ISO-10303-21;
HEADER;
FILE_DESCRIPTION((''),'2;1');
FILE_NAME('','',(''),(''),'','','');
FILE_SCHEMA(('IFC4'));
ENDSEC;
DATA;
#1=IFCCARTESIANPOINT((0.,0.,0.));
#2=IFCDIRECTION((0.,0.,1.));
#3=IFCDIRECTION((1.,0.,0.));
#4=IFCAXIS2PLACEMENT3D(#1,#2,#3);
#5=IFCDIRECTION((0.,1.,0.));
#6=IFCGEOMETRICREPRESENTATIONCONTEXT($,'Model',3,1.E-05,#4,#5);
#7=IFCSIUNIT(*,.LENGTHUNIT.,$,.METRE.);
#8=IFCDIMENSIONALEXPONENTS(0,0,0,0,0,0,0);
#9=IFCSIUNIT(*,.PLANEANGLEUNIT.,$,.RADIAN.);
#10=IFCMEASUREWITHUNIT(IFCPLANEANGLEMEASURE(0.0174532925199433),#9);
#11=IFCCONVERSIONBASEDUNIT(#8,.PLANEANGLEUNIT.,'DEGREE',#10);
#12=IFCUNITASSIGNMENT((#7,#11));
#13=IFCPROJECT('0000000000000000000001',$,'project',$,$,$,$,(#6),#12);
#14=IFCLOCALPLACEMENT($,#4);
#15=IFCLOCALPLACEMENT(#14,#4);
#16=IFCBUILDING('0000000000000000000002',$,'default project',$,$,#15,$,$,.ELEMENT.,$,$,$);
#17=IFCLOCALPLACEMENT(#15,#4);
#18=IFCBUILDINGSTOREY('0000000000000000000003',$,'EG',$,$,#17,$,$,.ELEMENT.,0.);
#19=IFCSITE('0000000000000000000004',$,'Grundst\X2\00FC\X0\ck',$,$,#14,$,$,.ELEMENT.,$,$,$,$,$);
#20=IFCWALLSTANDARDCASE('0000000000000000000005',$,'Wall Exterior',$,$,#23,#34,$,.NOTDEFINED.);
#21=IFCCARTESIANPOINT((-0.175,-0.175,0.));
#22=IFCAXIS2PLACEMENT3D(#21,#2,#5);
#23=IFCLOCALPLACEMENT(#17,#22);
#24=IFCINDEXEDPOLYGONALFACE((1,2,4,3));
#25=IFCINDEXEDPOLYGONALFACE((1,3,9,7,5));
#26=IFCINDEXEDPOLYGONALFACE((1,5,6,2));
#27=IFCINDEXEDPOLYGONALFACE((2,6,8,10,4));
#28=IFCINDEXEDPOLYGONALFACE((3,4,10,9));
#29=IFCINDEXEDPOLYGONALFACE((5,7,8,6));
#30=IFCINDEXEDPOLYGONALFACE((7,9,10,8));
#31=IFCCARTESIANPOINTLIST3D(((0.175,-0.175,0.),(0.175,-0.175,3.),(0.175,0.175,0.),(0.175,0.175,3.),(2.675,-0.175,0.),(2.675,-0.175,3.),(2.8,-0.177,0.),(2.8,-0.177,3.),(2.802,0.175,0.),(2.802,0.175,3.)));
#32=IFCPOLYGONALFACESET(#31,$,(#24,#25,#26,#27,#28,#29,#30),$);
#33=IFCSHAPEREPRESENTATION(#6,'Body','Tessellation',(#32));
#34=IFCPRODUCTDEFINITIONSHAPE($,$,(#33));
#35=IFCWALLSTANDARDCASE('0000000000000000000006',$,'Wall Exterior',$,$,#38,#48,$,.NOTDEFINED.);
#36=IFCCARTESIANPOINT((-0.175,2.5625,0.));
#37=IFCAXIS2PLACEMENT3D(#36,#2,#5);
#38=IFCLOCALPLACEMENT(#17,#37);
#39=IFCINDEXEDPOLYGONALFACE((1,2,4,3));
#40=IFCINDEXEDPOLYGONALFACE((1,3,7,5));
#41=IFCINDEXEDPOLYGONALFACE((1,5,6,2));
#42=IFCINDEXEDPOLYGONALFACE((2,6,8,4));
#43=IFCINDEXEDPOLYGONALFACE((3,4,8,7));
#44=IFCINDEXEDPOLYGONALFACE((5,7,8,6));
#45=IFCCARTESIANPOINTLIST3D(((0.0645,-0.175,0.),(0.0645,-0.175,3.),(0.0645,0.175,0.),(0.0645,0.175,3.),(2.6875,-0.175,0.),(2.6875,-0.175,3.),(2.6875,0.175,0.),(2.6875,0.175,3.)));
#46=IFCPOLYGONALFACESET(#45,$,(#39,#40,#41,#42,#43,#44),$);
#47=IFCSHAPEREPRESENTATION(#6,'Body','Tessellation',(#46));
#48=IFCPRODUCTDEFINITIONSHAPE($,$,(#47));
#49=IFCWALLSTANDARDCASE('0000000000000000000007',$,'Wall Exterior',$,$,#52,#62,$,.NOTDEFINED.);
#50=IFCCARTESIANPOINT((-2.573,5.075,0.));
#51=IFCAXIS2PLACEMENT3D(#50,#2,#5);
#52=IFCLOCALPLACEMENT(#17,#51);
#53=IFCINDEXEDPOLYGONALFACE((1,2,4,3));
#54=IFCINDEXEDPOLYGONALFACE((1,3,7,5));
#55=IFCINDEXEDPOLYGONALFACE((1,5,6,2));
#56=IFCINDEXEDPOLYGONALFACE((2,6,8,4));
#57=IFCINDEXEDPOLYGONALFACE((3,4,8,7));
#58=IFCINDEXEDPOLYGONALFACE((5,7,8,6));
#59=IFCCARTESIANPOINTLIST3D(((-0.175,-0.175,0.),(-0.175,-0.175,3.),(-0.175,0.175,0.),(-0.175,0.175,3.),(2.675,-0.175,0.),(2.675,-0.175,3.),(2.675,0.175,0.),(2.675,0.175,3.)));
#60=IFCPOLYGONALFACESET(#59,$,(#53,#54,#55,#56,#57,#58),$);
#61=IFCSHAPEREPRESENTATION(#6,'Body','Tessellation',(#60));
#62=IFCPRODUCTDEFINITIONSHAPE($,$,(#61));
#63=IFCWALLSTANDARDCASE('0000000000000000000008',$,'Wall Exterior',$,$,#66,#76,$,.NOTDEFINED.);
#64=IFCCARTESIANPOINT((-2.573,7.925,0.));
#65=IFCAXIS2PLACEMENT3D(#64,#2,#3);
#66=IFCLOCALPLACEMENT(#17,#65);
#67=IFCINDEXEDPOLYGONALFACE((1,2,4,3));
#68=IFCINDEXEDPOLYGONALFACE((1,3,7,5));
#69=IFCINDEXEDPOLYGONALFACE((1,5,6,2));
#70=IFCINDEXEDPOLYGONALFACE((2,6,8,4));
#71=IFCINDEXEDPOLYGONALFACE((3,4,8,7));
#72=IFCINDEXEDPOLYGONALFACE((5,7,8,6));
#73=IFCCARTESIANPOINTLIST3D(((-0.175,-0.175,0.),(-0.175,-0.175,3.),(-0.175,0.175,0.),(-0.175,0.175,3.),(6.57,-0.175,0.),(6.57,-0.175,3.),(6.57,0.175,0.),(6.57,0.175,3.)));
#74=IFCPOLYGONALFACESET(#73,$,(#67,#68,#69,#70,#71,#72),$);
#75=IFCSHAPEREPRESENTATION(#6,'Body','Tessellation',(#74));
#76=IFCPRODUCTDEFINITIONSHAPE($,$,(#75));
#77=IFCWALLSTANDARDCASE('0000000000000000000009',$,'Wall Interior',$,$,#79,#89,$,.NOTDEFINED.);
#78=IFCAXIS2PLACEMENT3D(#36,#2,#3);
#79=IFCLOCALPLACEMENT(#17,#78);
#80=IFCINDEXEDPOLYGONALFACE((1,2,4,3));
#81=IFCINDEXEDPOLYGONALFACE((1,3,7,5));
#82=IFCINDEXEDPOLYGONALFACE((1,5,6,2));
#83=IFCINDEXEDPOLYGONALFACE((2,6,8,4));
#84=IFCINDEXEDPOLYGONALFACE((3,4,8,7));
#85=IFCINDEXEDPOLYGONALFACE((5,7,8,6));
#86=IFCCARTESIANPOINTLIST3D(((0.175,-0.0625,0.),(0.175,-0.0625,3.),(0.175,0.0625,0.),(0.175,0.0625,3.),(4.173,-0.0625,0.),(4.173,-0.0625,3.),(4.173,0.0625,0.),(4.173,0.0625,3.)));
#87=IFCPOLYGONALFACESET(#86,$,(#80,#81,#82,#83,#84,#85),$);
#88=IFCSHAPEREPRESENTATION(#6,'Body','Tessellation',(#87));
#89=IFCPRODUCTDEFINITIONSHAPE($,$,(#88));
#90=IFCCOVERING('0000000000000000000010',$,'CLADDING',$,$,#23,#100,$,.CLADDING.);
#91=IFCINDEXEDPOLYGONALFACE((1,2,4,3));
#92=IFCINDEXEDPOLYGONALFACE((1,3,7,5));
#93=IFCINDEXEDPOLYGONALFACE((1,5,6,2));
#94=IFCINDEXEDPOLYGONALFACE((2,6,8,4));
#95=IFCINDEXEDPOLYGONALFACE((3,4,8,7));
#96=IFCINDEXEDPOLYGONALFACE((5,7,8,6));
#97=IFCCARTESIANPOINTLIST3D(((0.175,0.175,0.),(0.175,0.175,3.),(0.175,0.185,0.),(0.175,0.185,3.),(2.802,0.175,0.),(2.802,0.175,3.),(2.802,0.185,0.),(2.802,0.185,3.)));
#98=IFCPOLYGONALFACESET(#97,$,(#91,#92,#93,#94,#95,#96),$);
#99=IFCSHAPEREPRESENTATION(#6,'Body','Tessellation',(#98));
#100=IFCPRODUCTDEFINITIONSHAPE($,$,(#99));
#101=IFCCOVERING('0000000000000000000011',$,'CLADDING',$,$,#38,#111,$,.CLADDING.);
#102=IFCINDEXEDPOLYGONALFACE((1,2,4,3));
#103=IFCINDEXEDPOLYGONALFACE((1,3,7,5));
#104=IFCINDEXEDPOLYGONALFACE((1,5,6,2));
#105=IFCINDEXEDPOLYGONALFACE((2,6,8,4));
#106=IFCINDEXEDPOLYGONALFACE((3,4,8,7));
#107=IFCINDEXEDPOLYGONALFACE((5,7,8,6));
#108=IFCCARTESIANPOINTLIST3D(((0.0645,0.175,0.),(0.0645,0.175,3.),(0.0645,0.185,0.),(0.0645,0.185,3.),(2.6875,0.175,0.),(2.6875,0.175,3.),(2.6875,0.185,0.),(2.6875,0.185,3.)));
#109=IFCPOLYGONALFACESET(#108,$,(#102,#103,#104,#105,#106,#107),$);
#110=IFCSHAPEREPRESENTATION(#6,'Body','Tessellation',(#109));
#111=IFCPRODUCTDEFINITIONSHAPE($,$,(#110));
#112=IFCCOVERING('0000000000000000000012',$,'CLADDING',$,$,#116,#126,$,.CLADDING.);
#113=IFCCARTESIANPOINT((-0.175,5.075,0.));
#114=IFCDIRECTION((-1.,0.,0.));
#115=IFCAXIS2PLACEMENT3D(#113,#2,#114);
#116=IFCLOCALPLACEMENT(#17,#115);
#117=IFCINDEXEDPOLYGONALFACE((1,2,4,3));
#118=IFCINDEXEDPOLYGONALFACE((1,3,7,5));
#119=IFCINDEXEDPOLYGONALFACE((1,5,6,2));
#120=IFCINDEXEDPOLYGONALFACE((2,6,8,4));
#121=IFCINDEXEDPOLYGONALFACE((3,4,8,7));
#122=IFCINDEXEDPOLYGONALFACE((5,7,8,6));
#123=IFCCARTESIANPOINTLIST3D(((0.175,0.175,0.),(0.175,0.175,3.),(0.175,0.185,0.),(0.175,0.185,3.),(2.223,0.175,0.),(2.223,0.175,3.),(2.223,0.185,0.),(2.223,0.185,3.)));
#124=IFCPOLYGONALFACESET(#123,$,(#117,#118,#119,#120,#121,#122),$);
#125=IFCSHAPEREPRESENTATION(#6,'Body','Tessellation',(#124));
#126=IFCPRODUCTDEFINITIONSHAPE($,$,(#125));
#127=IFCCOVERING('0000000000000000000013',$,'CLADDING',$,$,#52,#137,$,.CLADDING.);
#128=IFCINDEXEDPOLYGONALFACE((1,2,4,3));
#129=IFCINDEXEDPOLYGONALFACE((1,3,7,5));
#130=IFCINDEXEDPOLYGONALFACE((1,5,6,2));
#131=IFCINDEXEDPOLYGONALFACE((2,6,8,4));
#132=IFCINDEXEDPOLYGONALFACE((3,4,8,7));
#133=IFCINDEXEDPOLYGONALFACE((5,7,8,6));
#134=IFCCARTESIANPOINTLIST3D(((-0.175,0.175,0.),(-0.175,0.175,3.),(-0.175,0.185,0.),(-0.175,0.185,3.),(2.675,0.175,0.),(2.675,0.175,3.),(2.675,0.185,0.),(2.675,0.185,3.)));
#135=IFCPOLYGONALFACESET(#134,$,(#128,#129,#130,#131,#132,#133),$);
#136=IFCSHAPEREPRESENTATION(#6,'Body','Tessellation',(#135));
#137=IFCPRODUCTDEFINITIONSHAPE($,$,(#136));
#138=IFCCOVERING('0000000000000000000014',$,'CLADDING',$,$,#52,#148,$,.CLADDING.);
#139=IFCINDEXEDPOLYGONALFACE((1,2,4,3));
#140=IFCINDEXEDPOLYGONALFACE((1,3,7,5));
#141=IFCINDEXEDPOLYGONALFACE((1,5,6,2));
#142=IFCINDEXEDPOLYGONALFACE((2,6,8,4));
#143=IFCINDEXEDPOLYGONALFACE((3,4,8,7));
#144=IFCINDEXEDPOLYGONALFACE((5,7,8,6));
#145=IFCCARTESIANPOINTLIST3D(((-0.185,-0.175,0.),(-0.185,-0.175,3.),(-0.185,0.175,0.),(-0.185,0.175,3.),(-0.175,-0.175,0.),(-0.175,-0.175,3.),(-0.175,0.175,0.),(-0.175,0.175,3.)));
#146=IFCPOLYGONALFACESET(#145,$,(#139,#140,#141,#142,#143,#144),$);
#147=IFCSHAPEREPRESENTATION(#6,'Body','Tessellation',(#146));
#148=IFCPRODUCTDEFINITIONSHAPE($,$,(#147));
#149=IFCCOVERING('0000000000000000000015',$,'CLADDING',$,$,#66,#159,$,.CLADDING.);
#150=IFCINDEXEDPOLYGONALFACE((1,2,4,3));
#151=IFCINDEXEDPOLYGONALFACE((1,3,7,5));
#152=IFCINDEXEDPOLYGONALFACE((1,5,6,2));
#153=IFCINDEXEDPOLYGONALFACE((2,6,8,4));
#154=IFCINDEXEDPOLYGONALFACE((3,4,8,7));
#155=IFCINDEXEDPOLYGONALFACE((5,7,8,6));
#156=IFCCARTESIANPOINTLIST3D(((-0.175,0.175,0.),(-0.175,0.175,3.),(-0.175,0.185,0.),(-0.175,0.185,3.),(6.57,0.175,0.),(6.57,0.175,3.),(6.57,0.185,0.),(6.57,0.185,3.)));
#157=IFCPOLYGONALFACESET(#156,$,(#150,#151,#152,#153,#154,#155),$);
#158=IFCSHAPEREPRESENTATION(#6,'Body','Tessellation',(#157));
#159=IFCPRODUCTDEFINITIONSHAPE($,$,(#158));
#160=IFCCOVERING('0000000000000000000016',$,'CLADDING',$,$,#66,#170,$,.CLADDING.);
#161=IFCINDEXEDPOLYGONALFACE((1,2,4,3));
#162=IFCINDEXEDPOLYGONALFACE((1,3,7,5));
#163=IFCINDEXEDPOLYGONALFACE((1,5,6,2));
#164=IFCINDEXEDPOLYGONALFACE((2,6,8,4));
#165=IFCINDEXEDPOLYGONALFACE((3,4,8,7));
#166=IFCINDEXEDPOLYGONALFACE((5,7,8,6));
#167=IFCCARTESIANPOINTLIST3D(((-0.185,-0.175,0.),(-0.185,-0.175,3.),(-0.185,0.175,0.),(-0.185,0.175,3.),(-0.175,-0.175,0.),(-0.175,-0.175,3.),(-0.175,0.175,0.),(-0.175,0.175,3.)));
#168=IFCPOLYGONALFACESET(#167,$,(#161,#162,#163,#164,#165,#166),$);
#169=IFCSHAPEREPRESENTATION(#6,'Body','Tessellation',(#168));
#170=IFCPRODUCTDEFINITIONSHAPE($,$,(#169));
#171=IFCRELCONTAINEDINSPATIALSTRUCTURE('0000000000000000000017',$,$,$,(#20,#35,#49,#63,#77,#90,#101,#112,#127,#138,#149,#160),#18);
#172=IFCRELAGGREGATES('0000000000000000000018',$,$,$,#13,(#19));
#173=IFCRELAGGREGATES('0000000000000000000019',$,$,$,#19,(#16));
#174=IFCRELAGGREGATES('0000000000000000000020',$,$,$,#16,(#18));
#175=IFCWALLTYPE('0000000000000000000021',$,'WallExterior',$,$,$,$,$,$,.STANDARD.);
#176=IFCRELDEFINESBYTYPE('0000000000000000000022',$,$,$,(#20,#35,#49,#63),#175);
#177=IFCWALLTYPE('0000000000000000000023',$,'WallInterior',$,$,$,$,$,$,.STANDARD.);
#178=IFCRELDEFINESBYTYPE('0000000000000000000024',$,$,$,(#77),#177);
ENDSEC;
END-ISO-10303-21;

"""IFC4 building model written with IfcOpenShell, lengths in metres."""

from ifc_helpers import new_model, entity, si_unit, converted_unit, direction, frame, origin_with_axes, place, context, project, spatial, polyline, outline, extrude, type_object, element, save


model = new_model("IFC4")

# Units and contexts
model_context = context("Model", 3, precision=1e-05, world=origin_with_axes(), true_north=direction((0.0, 1.0, 0.0)))
ifc_project = project(units=[si_unit("LENGTHUNIT", "METRE"), converted_unit("PLANEANGLEUNIT", "DEGREE", entity("IfcPlaneAngleMeasure", 0.0174532925199433), si_unit("PLANEANGLEUNIT", "RADIAN"), dimensions=[0, 0, 0, 0, 0, 0, 0])], contexts=[model_context])

# Site, building, storey
site_placement = place(None, origin_with_axes())
site = spatial("IfcSite", under=ifc_project, at=site_placement, Name="Grundstück", CompositionType="ELEMENT")
building_placement = place(site_placement, origin_with_axes())
building = spatial("IfcBuilding", under=site, at=building_placement, Name="default project", CompositionType="ELEMENT")
placement_1 = place(building_placement, origin_with_axes())
storey = spatial("IfcBuildingStorey", under=building, at=placement_1, Name="EG", CompositionType="ELEMENT", Elevation=0.0)

# Walls
wall_type_1 = type_object("IfcWallType", Name="WallExterior", PredefinedType="STANDARD")
placement_2 = place(placement_1, frame((-0.175, -0.175, 0.0), z_axis=(0.0, 0.0, 1.0), x_axis=(0.0, 1.0, 0.0)))
element("IfcWallStandardCase", 1, at=placement_2, inside=storey, type_object=wall_type_1, Name="Wall Exterior", PredefinedType="NOTDEFINED", context=model_context, shape_type="SweptSolid", body=[
    extrude(outline(polyline([(2.802, 0.175), (0.175, 0.175), (0.175, -0.175), (2.675, -0.175), (2.8, -0.177), (2.802, 0.175)])), origin_with_axes(), (0.0, 0.0, 1.0), 3.0),
])
placement_3 = place(placement_1, frame((-0.175, 2.5625, 0.0), z_axis=(0.0, 0.0, 1.0), x_axis=(0.0, 1.0, 0.0)))
element("IfcWallStandardCase", 2, at=placement_3, inside=storey, type_object=wall_type_1, Name="Wall Exterior", PredefinedType="NOTDEFINED", context=model_context, shape_type="SweptSolid", body=[
    extrude(outline(polyline([(0.0645, -0.175), (2.6875, -0.175), (2.6875, 0.175), (0.0645, 0.175), (0.0645, -0.175)])), origin_with_axes(), (0.0, 0.0, 1.0), 3.0),
])
placement_4 = place(placement_1, frame((-0.175, 5.075, 0.0), z_axis=(0.0, 0.0, 1.0), x_axis=(-1.0, 0.0, 0.0)))
placement_5 = place(placement_1, frame((-2.573, 5.075, 0.0), z_axis=(0.0, 0.0, 1.0), x_axis=(0.0, 1.0, 0.0)))
element("IfcWallStandardCase", 3, at=placement_5, inside=storey, type_object=wall_type_1, Name="Wall Exterior", PredefinedType="NOTDEFINED", context=model_context, shape_type="SweptSolid", body=[
    extrude(outline(polyline([(2.675, -0.175), (2.675, 0.175), (-0.175, 0.175), (-0.175, -0.175), (2.675, -0.175)])), origin_with_axes(), (0.0, 0.0, 1.0), 3.0),
])
placement_6 = place(placement_1, frame((-2.573, 7.925, 0.0), z_axis=(0.0, 0.0, 1.0), x_axis=(1.0, 0.0, 0.0)))
element("IfcWallStandardCase", 4, at=placement_6, inside=storey, type_object=wall_type_1, Name="Wall Exterior", PredefinedType="NOTDEFINED", context=model_context, shape_type="SweptSolid", body=[
    extrude(outline(polyline([(6.57, -0.175), (6.57, 0.175), (-0.175, 0.175), (-0.175, -0.175), (6.57, -0.175)])), origin_with_axes(), (0.0, 0.0, 1.0), 3.0),
])
wall_type_2 = type_object("IfcWallType", Name="WallInterior", PredefinedType="STANDARD")
wall_1_placement = place(placement_1, frame((-0.175, 2.5625, 0.0), z_axis=(0.0, 0.0, 1.0), x_axis=(1.0, 0.0, 0.0)))
element("IfcWallStandardCase", 5, at=wall_1_placement, inside=storey, type_object=wall_type_2, Name="Wall Interior", PredefinedType="NOTDEFINED", context=model_context, shape_type="SweptSolid", body=[
    extrude(outline(polyline([(4.173, 0.0625), (0.175, 0.0625), (0.175, -0.0625), (4.173, -0.0625), (4.173, 0.0625)])), origin_with_axes(), (0.0, 0.0, 1.0), 3.0),
])

# Coverings
element("IfcCovering", 6, at=placement_2, inside=storey, Name="CLADDING", PredefinedType="CLADDING", context=model_context, shape_type="SweptSolid", body=[
    extrude(outline(polyline([(2.802, 0.185), (0.175, 0.185), (0.175, 0.175), (2.802, 0.175), (2.802, 0.185)])), origin_with_axes(), (0.0, 0.0, 1.0), 3.0),
])
element("IfcCovering", 7, at=placement_3, inside=storey, Name="CLADDING", PredefinedType="CLADDING", context=model_context, shape_type="SweptSolid", body=[
    extrude(outline(polyline([(2.6875, 0.185), (0.0645, 0.185), (0.0645, 0.175), (2.6875, 0.175), (2.6875, 0.185)])), origin_with_axes(), (0.0, 0.0, 1.0), 3.0),
])
element("IfcCovering", 8, at=placement_4, inside=storey, Name="CLADDING", PredefinedType="CLADDING", context=model_context, shape_type="SweptSolid", body=[
    extrude(outline(polyline([(2.223, 0.185), (0.175, 0.185), (0.175, 0.175), (2.223, 0.175), (2.223, 0.185)])), origin_with_axes(), (0.0, 0.0, 1.0), 3.0),
])
element("IfcCovering", 9, at=placement_5, inside=storey, Name="CLADDING", PredefinedType="CLADDING", context=model_context, shape_type="SweptSolid", body=[
    extrude(outline(polyline([(2.675, 0.185), (-0.175, 0.185), (-0.175, 0.175), (2.675, 0.175), (2.675, 0.185)])), origin_with_axes(), (0.0, 0.0, 1.0), 3.0),
])
element("IfcCovering", 10, at=placement_5, inside=storey, Name="CLADDING", PredefinedType="CLADDING", context=model_context, shape_type="SweptSolid", body=[
    extrude(outline(polyline([(-0.185, 0.175), (-0.185, -0.175), (-0.175, -0.175), (-0.175, 0.175), (-0.185, 0.175)])), origin_with_axes(), (0.0, 0.0, 1.0), 3.0),
])
element("IfcCovering", 11, at=placement_6, inside=storey, Name="CLADDING", PredefinedType="CLADDING", context=model_context, shape_type="SweptSolid", body=[
    extrude(outline(polyline([(6.57, 0.185), (-0.175, 0.185), (-0.175, 0.175), (6.57, 0.175), (6.57, 0.185)])), origin_with_axes(), (0.0, 0.0, 1.0), 3.0),
])
element("IfcCovering", 12, at=placement_6, inside=storey, Name="CLADDING", PredefinedType="CLADDING", context=model_context, shape_type="SweptSolid", body=[
    extrude(outline(polyline([(-0.185, 0.175), (-0.185, -0.175), (-0.175, -0.175), (-0.175, 0.175), (-0.185, 0.175)])), origin_with_axes(), (0.0, 0.0, 1.0), 3.0),
])

save(model, "model.ifc")
